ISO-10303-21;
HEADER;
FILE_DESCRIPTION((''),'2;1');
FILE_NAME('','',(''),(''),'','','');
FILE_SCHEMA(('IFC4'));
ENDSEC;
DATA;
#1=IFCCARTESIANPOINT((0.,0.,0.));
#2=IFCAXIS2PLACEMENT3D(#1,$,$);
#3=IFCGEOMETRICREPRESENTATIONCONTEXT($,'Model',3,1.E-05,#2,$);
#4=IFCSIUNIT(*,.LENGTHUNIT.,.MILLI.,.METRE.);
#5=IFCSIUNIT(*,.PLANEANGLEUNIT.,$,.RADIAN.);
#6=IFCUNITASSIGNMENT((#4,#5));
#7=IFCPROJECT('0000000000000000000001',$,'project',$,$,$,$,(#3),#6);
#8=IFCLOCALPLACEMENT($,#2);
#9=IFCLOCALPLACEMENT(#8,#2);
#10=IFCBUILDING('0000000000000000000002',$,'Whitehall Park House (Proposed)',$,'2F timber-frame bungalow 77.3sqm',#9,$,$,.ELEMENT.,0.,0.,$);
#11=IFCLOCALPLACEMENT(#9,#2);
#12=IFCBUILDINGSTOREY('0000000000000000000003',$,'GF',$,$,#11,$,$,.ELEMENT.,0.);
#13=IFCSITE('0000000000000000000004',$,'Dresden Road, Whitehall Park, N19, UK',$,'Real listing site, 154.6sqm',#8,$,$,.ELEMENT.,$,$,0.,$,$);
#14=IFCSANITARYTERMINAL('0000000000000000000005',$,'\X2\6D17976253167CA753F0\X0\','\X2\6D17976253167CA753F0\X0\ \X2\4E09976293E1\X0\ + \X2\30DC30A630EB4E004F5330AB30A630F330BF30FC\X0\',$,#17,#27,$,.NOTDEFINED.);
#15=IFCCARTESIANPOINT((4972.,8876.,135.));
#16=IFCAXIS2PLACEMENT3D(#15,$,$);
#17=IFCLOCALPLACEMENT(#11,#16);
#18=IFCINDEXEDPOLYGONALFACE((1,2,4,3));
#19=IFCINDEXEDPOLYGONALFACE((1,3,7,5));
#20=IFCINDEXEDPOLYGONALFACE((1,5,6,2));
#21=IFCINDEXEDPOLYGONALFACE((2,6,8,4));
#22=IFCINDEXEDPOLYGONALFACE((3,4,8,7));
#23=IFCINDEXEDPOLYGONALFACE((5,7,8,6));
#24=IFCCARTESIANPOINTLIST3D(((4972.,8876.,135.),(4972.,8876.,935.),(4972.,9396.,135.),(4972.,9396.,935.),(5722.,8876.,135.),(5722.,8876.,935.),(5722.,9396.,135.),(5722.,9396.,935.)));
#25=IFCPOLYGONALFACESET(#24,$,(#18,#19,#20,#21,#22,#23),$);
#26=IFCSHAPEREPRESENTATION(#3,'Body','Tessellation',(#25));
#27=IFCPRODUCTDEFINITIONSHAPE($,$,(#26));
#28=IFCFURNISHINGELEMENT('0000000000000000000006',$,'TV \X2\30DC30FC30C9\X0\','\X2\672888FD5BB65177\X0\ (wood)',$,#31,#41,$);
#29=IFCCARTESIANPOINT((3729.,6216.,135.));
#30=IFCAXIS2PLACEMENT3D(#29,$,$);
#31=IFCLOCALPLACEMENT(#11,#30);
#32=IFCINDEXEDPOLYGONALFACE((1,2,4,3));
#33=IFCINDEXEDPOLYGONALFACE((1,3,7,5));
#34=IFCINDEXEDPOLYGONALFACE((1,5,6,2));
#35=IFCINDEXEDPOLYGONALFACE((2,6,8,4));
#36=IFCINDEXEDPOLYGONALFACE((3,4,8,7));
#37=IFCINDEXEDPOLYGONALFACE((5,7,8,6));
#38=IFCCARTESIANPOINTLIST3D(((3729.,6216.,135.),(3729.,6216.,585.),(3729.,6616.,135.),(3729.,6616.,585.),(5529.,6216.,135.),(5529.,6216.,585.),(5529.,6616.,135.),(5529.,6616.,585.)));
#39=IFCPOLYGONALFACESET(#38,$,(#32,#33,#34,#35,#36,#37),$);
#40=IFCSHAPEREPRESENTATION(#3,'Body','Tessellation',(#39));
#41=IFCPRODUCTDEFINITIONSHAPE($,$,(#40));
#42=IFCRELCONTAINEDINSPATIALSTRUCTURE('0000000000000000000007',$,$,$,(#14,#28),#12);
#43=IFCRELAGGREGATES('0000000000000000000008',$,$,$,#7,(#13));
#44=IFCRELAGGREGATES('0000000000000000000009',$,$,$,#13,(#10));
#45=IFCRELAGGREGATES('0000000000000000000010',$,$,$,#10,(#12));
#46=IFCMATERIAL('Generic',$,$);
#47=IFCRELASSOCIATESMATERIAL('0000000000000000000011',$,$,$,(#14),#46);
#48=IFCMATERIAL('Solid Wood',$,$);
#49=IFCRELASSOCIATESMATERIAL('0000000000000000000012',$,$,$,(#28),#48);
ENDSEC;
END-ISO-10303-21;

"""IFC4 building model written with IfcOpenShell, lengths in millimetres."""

from ifc_helpers import new_model, si_unit, frame, frame_2d, origin, place, context, project, spatial, rectangle, extrude, material, element, save


model = new_model("IFC4")

# Units and contexts
model_context = context("Model", 3, precision=1e-05, world=origin())
ifc_project = project(units=[si_unit("LENGTHUNIT", "METRE", prefix="MILLI"), si_unit("PLANEANGLEUNIT", "RADIAN")], contexts=[model_context])

# Site, building, storey
site_placement = place(None, origin())
site = spatial("IfcSite", under=ifc_project, at=site_placement, Name="Dresden Road, Whitehall Park, N19, UK", ObjectType="Real listing site, 154.6sqm", CompositionType="ELEMENT", RefElevation=0.0)
building_placement = place(site_placement, origin())
building = spatial("IfcBuilding", under=site, at=building_placement, Name="Whitehall Park House (Proposed)", ObjectType="2F timber-frame bungalow 77.3sqm", CompositionType="ELEMENT", ElevationOfRefHeight=0.0, ElevationOfTerrain=0.0)
storey_placement = place(building_placement, origin())
storey = spatial("IfcBuildingStorey", under=building, at=storey_placement, Name="GF", CompositionType="ELEMENT", Elevation=0.0)

# Shared definitions
ifc_material_1 = material(Name="Solid Wood")

# Shared definitions
ifc_material_2 = material(Name="Generic")

# Sanitary terminal
sanitary_terminal_1_placement = place(storey_placement, frame((4972.0, 8876.0, 135.0)))
element("IfcSanitaryTerminal", 1, at=sanitary_terminal_1_placement, inside=storey, material=ifc_material_2, Name="洗面化粧台", Description="洗面化粧台 三面鏡 + ボウル一体カウンター", PredefinedType="NOTDEFINED", context=model_context, shape_type="SweptSolid", body=[
    extrude(rectangle(XDim=750.0, YDim=520.0, at=frame_2d((375.0, 260.0))), frame((4972.0, 8876.0, 135.0)), (0.0, 0.0, 1.0), 800.0),
])

# Furnishing element
furnishing_placement = place(storey_placement, frame((3729.0, 6216.0, 135.0)))
element("IfcFurnishingElement", 2, at=furnishing_placement, inside=storey, material=ifc_material_1, Name="TV ボード", Description="木製家具 (wood)", context=model_context, shape_type="SweptSolid", body=[
    extrude(rectangle(XDim=1800.0, YDim=400.0, at=frame_2d((900.0, 200.0))), frame((3729.0, 6216.0, 135.0)), (0.0, 0.0, 1.0), 450.0),
])

save(model, "model.ifc")
